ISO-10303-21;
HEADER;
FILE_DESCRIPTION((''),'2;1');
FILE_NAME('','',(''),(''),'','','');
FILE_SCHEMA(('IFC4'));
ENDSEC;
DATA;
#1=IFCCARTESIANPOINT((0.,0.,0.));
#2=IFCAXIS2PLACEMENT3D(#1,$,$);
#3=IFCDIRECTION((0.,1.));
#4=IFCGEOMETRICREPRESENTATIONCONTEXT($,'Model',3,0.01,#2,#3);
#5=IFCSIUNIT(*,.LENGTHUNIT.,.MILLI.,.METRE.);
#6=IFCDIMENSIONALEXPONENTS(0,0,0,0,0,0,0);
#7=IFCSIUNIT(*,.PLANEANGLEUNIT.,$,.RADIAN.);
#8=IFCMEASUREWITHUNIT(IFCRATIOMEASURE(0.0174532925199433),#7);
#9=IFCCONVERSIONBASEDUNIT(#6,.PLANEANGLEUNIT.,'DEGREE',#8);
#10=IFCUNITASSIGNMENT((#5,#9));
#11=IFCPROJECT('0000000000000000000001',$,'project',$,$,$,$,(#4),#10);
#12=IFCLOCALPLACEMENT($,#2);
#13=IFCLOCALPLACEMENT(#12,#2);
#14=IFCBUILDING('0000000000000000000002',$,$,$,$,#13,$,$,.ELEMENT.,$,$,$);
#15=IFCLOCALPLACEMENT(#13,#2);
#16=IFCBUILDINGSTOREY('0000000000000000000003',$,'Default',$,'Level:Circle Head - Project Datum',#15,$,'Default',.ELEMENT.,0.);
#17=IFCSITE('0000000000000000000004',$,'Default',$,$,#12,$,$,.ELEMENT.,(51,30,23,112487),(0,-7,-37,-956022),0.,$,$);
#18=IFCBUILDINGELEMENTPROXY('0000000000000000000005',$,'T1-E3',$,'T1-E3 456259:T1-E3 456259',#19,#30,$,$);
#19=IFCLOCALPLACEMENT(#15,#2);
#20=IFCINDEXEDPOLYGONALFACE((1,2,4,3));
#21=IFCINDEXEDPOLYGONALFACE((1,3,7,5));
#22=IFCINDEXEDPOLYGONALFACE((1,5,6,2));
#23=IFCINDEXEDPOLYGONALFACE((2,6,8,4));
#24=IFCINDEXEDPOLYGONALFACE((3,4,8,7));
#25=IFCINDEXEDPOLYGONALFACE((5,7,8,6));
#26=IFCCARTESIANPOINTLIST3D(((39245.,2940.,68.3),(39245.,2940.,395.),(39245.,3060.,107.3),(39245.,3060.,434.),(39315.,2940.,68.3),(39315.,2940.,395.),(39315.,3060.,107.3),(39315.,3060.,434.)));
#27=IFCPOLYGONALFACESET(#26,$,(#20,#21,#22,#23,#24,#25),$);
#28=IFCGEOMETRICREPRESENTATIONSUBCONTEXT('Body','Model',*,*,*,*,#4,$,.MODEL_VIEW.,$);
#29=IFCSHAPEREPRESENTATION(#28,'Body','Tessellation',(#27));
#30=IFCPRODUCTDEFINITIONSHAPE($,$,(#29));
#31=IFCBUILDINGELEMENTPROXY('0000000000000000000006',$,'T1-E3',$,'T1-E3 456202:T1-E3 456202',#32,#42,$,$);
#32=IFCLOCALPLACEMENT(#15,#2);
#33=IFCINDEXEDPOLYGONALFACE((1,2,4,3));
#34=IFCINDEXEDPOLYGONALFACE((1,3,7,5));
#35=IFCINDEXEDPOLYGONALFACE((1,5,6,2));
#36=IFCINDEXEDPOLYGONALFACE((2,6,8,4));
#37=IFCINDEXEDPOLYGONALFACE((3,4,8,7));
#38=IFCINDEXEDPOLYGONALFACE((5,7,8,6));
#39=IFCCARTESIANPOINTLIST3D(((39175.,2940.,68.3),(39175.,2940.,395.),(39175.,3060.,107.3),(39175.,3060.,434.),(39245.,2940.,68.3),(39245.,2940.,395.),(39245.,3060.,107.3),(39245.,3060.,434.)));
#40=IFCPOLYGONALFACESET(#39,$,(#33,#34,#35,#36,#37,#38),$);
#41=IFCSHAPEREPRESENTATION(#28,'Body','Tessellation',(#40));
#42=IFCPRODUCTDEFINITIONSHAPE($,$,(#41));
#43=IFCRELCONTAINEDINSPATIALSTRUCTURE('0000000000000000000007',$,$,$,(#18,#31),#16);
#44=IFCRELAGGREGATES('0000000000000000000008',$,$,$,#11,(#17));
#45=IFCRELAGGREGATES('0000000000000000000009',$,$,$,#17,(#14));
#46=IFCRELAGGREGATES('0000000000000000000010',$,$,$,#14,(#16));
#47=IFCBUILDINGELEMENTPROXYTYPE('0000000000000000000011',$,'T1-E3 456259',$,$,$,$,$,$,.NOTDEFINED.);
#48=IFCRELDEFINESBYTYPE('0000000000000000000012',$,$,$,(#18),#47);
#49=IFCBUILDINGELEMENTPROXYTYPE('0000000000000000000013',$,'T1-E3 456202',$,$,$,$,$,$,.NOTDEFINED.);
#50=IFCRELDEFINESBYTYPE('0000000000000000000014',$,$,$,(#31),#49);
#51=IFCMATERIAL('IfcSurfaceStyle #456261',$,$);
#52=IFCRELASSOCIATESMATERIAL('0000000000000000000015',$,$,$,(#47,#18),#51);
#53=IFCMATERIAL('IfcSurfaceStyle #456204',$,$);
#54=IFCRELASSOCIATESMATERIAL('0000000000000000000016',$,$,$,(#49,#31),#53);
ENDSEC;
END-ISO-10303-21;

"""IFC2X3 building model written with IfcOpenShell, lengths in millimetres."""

from ifc_helpers import new_model, entity, si_unit, converted_unit, direction, frame, origin, place, context, subcontext, project, spatial, polyline, outline, extrude, source, transform, mapped, material, type_object, type_shapes, element, save


model = new_model("IFC2X3")

# Units and contexts
model_context = context("Model", 3, precision=0.01, world=origin(), true_north=direction((0.0, 1.0)))
body_context = subcontext(model_context, "Body", "Model", "MODEL_VIEW")
ifc_project = project(units=[si_unit("LENGTHUNIT", "METRE", prefix="MILLI"), converted_unit("PLANEANGLEUNIT", "DEGREE", entity("IfcRatioMeasure", 0.0174532925199433), si_unit("PLANEANGLEUNIT", "RADIAN"), dimensions=[0, 0, 0, 0, 0, 0, 0])], contexts=[model_context])

# Site, building, storey
site_placement = place(None, origin())
site = spatial("IfcSite", under=ifc_project, at=site_placement, Name="Default", CompositionType="ELEMENT", RefLatitude=(51, 30, 23, 112487), RefLongitude=(0, -7, -37, -956022), RefElevation=0.0)
building_placement = place(site_placement, origin())
building = spatial("IfcBuilding", under=site, at=building_placement, CompositionType="ELEMENT")
storey_placement = place(building_placement, origin())
storey = spatial("IfcBuildingStorey", under=building, at=storey_placement, Name="Default", ObjectType="Level:Circle Head - Project Datum", LongName="Default", CompositionType="ELEMENT", Elevation=0.0)

# Building element proxies
ifc_material_1 = material(Name="IfcSurfaceStyle #456261")
building_element_proxy_type_1 = type_object("IfcBuildingElementProxyType", Name="T1-E3 456259", PredefinedType="NOTDEFINED", material=ifc_material_1)
shared_shape_1 = source(origin(), body_context, "Body", "SweptSolid", [
    extrude(outline(polyline([(-182.8, -60.0), (143.8, -60.0), (182.8, 60.0), (-143.8, 60.0), (-182.8, -60.0)])), frame((182.8, 60.0, 0.0), z_axis=(0.0, 0.0, 1.0), x_axis=(-1.0, 0.0, 0.0)), (0.0, 0.0, 1.0), 70.0),
])
type_shapes(building_element_proxy_type_1, [shared_shape_1])
proxy_1_placement = place(building_placement, frame((39315.0, 2940.0, 68.3), z_axis=(-1.0, 0.0, 0.0), x_axis=(0.0, 0.0, 1.0)))
element("IfcBuildingElementProxy", 1, at=proxy_1_placement, inside=storey, type_object=building_element_proxy_type_1, material=ifc_material_1, Name="T1-E3", ObjectType="T1-E3 456259:T1-E3 456259", context=body_context, shape_type="MappedRepresentation", body=[
    mapped(shared_shape_1, transform((0.0, 0.0, 0.0), scale=1.0)),
])
ifc_material_2 = material(Name="IfcSurfaceStyle #456204")
building_element_proxy_type_2 = type_object("IfcBuildingElementProxyType", Name="T1-E3 456202", PredefinedType="NOTDEFINED", material=ifc_material_2)
shared_shape_2 = source(origin(), body_context, "Body", "SweptSolid", [
    extrude(outline(polyline([(-182.8, -60.0), (143.8, -60.0), (182.8, 60.0), (-143.8, 60.0), (-182.8, -60.0)])), frame((182.8, 60.0, 0.0), z_axis=(0.0, 0.0, 1.0), x_axis=(-1.0, 0.0, 0.0)), (0.0, 0.0, 1.0), 70.0),
])
type_shapes(building_element_proxy_type_2, [shared_shape_2])
proxy_2_placement = place(building_placement, frame((39245.0, 2940.0, 68.3), z_axis=(-1.0, 0.0, 0.0), x_axis=(0.0, 0.0, 1.0)))
element("IfcBuildingElementProxy", 2, at=proxy_2_placement, inside=storey, type_object=building_element_proxy_type_2, material=ifc_material_2, Name="T1-E3", ObjectType="T1-E3 456202:T1-E3 456202", context=body_context, shape_type="MappedRepresentation", body=[
    mapped(shared_shape_2, transform((0.0, 0.0, 0.0), scale=1.0)),
])

save(model, "model.ifc")
